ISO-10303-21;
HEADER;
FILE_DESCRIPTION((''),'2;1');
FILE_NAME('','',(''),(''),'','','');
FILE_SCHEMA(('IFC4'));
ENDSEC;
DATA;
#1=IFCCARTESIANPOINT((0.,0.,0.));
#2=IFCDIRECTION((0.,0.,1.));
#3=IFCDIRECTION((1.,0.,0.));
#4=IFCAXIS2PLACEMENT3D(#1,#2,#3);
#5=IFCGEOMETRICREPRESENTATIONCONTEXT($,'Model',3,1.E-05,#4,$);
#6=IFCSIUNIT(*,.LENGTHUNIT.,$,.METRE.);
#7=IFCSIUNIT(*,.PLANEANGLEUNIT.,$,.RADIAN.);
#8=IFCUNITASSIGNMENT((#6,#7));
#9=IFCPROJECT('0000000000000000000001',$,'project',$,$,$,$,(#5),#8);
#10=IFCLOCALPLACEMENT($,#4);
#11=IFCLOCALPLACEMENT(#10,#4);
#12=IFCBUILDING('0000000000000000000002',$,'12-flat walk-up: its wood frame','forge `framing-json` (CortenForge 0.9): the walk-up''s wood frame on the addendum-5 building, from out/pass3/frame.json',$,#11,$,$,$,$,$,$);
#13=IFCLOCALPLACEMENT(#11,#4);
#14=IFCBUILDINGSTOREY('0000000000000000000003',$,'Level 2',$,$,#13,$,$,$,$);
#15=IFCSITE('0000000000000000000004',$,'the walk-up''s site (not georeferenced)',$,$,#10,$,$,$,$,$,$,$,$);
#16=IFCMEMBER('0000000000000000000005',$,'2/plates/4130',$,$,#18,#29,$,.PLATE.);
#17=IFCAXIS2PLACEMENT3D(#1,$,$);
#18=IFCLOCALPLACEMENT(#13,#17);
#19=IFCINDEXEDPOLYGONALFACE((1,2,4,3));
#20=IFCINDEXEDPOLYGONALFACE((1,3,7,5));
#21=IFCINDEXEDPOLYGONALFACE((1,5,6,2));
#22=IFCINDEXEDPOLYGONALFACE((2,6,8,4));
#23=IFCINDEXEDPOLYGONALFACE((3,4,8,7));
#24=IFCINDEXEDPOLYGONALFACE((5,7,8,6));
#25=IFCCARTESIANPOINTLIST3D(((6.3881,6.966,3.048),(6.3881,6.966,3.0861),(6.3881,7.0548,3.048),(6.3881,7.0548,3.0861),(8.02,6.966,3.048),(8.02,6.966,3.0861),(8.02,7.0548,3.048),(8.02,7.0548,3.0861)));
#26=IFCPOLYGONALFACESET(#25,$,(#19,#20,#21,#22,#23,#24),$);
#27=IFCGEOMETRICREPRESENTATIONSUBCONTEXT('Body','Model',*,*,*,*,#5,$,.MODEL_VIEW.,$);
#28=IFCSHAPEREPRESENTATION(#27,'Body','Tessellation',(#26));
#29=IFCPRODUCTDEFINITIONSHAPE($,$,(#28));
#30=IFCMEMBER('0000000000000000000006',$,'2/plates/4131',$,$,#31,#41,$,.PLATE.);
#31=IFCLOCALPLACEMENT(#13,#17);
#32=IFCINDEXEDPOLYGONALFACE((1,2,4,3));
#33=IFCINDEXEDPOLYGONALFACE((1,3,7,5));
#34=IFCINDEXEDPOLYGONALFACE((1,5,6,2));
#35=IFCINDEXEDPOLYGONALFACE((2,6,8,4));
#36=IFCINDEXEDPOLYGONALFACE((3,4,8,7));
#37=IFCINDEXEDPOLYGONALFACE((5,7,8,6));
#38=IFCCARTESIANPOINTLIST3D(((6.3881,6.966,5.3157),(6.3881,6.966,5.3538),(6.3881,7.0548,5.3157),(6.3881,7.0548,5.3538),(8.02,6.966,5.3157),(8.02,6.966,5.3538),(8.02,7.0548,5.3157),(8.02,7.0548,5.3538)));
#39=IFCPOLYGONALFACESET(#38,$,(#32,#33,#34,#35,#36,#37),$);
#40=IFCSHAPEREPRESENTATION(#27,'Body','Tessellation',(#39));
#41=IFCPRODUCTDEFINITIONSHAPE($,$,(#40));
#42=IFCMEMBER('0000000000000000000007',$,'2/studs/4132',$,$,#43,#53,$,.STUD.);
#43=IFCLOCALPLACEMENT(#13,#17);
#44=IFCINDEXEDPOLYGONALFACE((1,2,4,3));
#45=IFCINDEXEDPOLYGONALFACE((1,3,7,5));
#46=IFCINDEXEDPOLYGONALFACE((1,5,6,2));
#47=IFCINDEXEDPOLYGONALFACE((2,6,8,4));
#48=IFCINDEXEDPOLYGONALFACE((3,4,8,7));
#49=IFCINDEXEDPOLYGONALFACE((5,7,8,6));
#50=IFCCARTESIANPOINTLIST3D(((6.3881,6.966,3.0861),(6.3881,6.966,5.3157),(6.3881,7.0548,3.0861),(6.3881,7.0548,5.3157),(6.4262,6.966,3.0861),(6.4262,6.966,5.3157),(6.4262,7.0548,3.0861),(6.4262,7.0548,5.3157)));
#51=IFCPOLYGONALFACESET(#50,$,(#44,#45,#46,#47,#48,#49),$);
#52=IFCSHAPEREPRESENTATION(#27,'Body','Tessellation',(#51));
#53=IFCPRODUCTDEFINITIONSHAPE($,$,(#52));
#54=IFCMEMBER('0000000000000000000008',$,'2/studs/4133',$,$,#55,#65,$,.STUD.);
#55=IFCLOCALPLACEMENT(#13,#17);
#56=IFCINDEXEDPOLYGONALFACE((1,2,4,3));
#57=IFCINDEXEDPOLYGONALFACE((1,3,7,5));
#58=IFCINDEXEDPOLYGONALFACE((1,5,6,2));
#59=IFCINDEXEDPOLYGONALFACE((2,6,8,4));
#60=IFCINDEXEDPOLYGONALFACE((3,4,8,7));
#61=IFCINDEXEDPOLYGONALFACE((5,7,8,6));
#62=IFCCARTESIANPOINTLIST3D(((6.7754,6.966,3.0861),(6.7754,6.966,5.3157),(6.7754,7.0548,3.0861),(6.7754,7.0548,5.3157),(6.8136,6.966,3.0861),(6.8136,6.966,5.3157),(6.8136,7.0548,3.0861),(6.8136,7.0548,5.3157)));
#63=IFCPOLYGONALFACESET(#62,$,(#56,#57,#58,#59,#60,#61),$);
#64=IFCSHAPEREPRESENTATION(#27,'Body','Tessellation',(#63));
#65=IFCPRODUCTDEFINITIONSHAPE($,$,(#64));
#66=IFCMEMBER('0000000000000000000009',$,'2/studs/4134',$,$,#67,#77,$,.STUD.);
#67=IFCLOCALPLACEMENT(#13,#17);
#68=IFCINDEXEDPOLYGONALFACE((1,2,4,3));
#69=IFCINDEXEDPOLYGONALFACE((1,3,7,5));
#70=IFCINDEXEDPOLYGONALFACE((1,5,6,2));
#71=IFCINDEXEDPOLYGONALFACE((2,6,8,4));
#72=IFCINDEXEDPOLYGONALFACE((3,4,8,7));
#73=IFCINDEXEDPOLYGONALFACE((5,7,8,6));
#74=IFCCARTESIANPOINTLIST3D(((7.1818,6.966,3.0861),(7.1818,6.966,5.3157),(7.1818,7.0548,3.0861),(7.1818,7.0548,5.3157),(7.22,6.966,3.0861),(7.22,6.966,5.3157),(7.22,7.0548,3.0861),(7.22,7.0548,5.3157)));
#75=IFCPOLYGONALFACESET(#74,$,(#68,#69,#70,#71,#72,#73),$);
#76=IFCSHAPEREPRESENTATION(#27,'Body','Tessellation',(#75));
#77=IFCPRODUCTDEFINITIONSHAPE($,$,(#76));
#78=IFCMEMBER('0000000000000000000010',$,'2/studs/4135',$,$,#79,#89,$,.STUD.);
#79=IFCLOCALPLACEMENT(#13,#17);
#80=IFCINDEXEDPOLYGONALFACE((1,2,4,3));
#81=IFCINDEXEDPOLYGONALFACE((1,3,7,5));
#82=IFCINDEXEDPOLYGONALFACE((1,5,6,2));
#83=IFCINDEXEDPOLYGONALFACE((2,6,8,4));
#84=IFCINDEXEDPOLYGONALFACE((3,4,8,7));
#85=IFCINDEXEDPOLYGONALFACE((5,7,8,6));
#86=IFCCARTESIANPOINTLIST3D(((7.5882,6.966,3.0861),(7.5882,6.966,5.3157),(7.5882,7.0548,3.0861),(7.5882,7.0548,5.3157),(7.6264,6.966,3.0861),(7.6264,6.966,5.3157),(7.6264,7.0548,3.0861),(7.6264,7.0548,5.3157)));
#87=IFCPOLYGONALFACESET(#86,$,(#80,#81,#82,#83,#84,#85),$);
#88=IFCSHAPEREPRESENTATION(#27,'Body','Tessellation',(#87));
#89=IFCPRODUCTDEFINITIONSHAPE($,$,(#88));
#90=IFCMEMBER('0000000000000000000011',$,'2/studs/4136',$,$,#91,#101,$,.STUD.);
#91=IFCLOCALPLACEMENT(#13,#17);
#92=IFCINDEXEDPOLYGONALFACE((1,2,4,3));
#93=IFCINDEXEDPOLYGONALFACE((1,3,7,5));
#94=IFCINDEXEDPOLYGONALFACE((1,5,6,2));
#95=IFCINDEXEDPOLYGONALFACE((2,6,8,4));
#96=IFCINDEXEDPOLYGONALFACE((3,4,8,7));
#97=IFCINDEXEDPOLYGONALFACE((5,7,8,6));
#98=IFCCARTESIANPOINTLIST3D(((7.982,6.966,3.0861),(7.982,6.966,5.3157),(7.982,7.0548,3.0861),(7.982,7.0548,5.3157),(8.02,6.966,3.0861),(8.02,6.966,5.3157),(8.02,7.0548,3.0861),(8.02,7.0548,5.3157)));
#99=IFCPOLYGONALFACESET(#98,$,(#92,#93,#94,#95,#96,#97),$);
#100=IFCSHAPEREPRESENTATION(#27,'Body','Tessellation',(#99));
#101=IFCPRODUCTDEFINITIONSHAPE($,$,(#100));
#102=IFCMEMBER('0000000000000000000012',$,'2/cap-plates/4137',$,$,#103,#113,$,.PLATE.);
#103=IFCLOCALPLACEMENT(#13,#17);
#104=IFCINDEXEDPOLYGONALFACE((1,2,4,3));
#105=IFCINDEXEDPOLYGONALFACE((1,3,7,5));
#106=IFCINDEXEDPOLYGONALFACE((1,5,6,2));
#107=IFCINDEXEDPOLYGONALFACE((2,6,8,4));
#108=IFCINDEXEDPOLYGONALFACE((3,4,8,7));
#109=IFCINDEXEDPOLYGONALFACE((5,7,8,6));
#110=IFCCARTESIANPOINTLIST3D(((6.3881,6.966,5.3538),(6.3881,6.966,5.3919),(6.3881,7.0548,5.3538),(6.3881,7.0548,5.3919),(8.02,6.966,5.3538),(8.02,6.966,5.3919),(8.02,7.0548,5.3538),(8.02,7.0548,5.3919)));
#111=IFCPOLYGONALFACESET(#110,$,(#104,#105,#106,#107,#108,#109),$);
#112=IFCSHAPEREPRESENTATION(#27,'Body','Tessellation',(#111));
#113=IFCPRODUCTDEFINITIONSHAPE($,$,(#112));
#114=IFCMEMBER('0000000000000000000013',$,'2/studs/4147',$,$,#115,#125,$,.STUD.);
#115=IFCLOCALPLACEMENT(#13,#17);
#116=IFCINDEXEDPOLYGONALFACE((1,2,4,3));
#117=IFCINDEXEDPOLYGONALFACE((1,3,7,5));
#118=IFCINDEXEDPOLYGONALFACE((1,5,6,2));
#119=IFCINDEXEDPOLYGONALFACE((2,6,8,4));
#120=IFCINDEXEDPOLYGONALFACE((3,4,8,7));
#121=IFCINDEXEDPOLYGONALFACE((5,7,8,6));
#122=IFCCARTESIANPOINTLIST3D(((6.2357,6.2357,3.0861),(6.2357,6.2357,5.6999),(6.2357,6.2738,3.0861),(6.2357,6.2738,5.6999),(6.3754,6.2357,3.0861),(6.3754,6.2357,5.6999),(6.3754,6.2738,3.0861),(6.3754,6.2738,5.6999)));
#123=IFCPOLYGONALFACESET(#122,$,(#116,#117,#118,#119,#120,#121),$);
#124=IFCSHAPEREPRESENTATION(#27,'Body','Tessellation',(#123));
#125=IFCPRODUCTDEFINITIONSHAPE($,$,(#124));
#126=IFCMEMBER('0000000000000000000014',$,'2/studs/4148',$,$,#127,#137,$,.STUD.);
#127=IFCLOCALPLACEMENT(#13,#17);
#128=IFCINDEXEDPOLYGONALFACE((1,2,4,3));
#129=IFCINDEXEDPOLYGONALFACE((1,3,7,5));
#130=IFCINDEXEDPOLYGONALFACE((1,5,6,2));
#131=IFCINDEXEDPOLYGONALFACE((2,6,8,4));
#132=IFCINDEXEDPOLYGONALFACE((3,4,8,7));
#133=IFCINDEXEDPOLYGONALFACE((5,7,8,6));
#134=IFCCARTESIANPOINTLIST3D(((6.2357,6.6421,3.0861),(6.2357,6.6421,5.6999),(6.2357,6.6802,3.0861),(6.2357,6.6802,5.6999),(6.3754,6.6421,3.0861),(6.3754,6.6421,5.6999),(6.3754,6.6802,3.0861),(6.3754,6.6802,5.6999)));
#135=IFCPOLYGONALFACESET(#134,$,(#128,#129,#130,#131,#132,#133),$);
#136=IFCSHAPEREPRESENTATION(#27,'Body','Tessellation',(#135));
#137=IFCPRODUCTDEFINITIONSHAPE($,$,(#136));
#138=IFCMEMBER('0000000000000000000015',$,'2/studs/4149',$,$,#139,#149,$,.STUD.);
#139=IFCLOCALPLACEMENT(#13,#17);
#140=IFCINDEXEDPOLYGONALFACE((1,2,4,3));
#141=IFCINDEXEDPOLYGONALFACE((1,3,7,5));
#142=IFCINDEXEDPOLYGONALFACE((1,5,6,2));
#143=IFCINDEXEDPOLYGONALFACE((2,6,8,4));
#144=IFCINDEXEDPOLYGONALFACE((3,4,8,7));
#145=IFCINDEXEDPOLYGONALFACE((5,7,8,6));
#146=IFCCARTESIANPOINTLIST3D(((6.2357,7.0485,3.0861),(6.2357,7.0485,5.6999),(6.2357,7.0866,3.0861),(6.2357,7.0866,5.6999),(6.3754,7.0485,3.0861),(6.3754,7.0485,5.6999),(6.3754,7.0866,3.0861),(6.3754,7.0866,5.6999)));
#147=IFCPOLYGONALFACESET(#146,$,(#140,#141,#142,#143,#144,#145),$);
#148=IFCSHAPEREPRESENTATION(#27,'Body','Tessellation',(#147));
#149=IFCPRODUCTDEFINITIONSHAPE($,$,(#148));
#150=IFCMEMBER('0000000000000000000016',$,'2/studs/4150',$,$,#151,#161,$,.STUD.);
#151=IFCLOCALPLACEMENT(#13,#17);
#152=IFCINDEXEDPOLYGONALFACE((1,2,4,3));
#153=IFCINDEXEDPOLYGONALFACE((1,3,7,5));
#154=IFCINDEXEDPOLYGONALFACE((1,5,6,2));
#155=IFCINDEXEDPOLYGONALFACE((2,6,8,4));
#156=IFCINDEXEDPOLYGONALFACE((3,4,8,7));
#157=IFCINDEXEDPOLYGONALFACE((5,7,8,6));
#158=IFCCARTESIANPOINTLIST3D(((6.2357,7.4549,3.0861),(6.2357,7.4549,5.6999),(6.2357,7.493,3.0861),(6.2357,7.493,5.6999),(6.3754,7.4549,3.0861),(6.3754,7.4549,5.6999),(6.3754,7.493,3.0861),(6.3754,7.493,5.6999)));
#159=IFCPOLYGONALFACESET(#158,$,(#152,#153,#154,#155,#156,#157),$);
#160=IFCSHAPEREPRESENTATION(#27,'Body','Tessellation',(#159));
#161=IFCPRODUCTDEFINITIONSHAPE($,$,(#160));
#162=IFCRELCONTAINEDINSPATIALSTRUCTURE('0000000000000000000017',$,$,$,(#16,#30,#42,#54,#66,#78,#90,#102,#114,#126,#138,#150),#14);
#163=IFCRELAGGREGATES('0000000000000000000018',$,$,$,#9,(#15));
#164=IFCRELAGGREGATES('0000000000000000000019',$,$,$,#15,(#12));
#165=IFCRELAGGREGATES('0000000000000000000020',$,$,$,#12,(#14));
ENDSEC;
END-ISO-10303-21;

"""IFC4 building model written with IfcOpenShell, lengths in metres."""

from ifc_helpers import new_model, si_unit, frame, frame_2d, origin, origin_with_axes, place, context, subcontext, project, spatial, rectangle, extrude, element, save


model = new_model("IFC4")

# Units and contexts
model_context = context("Model", 3, precision=1e-05, world=origin_with_axes())
body_context = subcontext(model_context, "Body", "Model", "MODEL_VIEW")
ifc_project = project(units=[si_unit("LENGTHUNIT", "METRE"), si_unit("PLANEANGLEUNIT", "RADIAN")], contexts=[model_context])

# Site, building, storey
site_placement = place(None, origin_with_axes())
site = spatial("IfcSite", under=ifc_project, at=site_placement, Name="the walk-up's site (not georeferenced)")
building_placement = place(site_placement, origin_with_axes())
building = spatial("IfcBuilding", under=site, at=building_placement, Name="12-flat walk-up: its wood frame", Description="forge `framing-json` (CortenForge 0.9): the walk-up's wood frame on the addendum-5 building, from out/pass3/frame.json")
storey_placement = place(building_placement, origin_with_axes())
storey = spatial("IfcBuildingStorey", under=building, at=storey_placement, Name="Level 2")

# Members
for number, where, z_axis, x_axis, name in (
    (1, (6.3881, 6.966, 3.048), (0.0, 0.0, 1.0), (1.0, 0.0, 0.0), "2/plates/4130"),
    (2, (6.3881, 6.966, 5.3157), (0.0, 0.0, 1.0), (1.0, 0.0, 0.0), "2/plates/4131"),
):
    element("IfcMember", number, at=place(storey_placement, frame(where, z_axis=z_axis, x_axis=x_axis)), inside=storey, Name=name, PredefinedType="PLATE", context=body_context, shape_type="SweptSolid", body=[
        extrude(rectangle(XDim=1.6319, YDim=0.0889, at=frame_2d((0.816, 0.0444))), origin(), (0.0, 0.0, 1.0), 0.0381),
    ])
for number, where, z_axis, x_axis, name in (
    (3, (6.3881, 6.966, 3.0861), (0.0, 0.0, 1.0), (1.0, 0.0, 0.0), "2/studs/4132"),
    (4, (6.7755, 6.966, 3.0861), (0.0, 0.0, 1.0), (1.0, 0.0, 0.0), "2/studs/4133"),
    (5, (7.1818, 6.966, 3.0861), (0.0, 0.0, 1.0), (1.0, 0.0, 0.0), "2/studs/4134"),
    (6, (7.5883, 6.966, 3.0861), (0.0, 0.0, 1.0), (1.0, 0.0, 0.0), "2/studs/4135"),
):
    element("IfcMember", number, at=place(storey_placement, frame(where, z_axis=z_axis, x_axis=x_axis)), inside=storey, Name=name, PredefinedType="STUD", context=body_context, shape_type="SweptSolid", body=[
        extrude(rectangle(XDim=0.0381, YDim=0.0889, at=frame_2d((0.0191, 0.0444))), origin(), (0.0, 0.0, 1.0), 2.2296),
    ])
member_1_placement = place(storey_placement, frame((7.982, 6.966, 3.0861), z_axis=(0.0, 0.0, 1.0), x_axis=(1.0, 0.0, 0.0)))
element("IfcMember", 7, at=member_1_placement, inside=storey, Name="2/studs/4136", PredefinedType="STUD", context=body_context, shape_type="SweptSolid", body=[
    extrude(rectangle(XDim=0.0381, YDim=0.0889, at=frame_2d((0.019, 0.0444))), origin(), (0.0, 0.0, 1.0), 2.2296),
])
member_2_placement = place(storey_placement, frame((6.3881, 6.966, 5.3538), z_axis=(0.0, 0.0, 1.0), x_axis=(1.0, 0.0, 0.0)))
element("IfcMember", 8, at=member_2_placement, inside=storey, Name="2/cap-plates/4137", PredefinedType="PLATE", context=body_context, shape_type="SweptSolid", body=[
    extrude(rectangle(XDim=1.6319, YDim=0.0889, at=frame_2d((0.816, 0.0444))), origin(), (0.0, 0.0, 1.0), 0.0381),
])
for number, where, z_axis, x_axis, name in (
    (9, (6.2357, 6.2357, 3.0861), (0.0, 0.0, 1.0), (1.0, 0.0, 0.0), "2/studs/4147"),
    (10, (6.2357, 6.6421, 3.0861), (0.0, 0.0, 1.0), (1.0, 0.0, 0.0), "2/studs/4148"),
    (11, (6.2357, 7.0485, 3.0861), (0.0, 0.0, 1.0), (1.0, 0.0, 0.0), "2/studs/4149"),
    (12, (6.2357, 7.4549, 3.0861), (0.0, 0.0, 1.0), (1.0, 0.0, 0.0), "2/studs/4150"),
):
    element("IfcMember", number, at=place(storey_placement, frame(where, z_axis=z_axis, x_axis=x_axis)), inside=storey, Name=name, PredefinedType="STUD", context=body_context, shape_type="SweptSolid", body=[
        extrude(rectangle(XDim=0.1397, YDim=0.0381, at=frame_2d((0.0699, 0.0191))), origin(), (0.0, 0.0, 1.0), 2.6138),
    ])

save(model, "model.ifc")
